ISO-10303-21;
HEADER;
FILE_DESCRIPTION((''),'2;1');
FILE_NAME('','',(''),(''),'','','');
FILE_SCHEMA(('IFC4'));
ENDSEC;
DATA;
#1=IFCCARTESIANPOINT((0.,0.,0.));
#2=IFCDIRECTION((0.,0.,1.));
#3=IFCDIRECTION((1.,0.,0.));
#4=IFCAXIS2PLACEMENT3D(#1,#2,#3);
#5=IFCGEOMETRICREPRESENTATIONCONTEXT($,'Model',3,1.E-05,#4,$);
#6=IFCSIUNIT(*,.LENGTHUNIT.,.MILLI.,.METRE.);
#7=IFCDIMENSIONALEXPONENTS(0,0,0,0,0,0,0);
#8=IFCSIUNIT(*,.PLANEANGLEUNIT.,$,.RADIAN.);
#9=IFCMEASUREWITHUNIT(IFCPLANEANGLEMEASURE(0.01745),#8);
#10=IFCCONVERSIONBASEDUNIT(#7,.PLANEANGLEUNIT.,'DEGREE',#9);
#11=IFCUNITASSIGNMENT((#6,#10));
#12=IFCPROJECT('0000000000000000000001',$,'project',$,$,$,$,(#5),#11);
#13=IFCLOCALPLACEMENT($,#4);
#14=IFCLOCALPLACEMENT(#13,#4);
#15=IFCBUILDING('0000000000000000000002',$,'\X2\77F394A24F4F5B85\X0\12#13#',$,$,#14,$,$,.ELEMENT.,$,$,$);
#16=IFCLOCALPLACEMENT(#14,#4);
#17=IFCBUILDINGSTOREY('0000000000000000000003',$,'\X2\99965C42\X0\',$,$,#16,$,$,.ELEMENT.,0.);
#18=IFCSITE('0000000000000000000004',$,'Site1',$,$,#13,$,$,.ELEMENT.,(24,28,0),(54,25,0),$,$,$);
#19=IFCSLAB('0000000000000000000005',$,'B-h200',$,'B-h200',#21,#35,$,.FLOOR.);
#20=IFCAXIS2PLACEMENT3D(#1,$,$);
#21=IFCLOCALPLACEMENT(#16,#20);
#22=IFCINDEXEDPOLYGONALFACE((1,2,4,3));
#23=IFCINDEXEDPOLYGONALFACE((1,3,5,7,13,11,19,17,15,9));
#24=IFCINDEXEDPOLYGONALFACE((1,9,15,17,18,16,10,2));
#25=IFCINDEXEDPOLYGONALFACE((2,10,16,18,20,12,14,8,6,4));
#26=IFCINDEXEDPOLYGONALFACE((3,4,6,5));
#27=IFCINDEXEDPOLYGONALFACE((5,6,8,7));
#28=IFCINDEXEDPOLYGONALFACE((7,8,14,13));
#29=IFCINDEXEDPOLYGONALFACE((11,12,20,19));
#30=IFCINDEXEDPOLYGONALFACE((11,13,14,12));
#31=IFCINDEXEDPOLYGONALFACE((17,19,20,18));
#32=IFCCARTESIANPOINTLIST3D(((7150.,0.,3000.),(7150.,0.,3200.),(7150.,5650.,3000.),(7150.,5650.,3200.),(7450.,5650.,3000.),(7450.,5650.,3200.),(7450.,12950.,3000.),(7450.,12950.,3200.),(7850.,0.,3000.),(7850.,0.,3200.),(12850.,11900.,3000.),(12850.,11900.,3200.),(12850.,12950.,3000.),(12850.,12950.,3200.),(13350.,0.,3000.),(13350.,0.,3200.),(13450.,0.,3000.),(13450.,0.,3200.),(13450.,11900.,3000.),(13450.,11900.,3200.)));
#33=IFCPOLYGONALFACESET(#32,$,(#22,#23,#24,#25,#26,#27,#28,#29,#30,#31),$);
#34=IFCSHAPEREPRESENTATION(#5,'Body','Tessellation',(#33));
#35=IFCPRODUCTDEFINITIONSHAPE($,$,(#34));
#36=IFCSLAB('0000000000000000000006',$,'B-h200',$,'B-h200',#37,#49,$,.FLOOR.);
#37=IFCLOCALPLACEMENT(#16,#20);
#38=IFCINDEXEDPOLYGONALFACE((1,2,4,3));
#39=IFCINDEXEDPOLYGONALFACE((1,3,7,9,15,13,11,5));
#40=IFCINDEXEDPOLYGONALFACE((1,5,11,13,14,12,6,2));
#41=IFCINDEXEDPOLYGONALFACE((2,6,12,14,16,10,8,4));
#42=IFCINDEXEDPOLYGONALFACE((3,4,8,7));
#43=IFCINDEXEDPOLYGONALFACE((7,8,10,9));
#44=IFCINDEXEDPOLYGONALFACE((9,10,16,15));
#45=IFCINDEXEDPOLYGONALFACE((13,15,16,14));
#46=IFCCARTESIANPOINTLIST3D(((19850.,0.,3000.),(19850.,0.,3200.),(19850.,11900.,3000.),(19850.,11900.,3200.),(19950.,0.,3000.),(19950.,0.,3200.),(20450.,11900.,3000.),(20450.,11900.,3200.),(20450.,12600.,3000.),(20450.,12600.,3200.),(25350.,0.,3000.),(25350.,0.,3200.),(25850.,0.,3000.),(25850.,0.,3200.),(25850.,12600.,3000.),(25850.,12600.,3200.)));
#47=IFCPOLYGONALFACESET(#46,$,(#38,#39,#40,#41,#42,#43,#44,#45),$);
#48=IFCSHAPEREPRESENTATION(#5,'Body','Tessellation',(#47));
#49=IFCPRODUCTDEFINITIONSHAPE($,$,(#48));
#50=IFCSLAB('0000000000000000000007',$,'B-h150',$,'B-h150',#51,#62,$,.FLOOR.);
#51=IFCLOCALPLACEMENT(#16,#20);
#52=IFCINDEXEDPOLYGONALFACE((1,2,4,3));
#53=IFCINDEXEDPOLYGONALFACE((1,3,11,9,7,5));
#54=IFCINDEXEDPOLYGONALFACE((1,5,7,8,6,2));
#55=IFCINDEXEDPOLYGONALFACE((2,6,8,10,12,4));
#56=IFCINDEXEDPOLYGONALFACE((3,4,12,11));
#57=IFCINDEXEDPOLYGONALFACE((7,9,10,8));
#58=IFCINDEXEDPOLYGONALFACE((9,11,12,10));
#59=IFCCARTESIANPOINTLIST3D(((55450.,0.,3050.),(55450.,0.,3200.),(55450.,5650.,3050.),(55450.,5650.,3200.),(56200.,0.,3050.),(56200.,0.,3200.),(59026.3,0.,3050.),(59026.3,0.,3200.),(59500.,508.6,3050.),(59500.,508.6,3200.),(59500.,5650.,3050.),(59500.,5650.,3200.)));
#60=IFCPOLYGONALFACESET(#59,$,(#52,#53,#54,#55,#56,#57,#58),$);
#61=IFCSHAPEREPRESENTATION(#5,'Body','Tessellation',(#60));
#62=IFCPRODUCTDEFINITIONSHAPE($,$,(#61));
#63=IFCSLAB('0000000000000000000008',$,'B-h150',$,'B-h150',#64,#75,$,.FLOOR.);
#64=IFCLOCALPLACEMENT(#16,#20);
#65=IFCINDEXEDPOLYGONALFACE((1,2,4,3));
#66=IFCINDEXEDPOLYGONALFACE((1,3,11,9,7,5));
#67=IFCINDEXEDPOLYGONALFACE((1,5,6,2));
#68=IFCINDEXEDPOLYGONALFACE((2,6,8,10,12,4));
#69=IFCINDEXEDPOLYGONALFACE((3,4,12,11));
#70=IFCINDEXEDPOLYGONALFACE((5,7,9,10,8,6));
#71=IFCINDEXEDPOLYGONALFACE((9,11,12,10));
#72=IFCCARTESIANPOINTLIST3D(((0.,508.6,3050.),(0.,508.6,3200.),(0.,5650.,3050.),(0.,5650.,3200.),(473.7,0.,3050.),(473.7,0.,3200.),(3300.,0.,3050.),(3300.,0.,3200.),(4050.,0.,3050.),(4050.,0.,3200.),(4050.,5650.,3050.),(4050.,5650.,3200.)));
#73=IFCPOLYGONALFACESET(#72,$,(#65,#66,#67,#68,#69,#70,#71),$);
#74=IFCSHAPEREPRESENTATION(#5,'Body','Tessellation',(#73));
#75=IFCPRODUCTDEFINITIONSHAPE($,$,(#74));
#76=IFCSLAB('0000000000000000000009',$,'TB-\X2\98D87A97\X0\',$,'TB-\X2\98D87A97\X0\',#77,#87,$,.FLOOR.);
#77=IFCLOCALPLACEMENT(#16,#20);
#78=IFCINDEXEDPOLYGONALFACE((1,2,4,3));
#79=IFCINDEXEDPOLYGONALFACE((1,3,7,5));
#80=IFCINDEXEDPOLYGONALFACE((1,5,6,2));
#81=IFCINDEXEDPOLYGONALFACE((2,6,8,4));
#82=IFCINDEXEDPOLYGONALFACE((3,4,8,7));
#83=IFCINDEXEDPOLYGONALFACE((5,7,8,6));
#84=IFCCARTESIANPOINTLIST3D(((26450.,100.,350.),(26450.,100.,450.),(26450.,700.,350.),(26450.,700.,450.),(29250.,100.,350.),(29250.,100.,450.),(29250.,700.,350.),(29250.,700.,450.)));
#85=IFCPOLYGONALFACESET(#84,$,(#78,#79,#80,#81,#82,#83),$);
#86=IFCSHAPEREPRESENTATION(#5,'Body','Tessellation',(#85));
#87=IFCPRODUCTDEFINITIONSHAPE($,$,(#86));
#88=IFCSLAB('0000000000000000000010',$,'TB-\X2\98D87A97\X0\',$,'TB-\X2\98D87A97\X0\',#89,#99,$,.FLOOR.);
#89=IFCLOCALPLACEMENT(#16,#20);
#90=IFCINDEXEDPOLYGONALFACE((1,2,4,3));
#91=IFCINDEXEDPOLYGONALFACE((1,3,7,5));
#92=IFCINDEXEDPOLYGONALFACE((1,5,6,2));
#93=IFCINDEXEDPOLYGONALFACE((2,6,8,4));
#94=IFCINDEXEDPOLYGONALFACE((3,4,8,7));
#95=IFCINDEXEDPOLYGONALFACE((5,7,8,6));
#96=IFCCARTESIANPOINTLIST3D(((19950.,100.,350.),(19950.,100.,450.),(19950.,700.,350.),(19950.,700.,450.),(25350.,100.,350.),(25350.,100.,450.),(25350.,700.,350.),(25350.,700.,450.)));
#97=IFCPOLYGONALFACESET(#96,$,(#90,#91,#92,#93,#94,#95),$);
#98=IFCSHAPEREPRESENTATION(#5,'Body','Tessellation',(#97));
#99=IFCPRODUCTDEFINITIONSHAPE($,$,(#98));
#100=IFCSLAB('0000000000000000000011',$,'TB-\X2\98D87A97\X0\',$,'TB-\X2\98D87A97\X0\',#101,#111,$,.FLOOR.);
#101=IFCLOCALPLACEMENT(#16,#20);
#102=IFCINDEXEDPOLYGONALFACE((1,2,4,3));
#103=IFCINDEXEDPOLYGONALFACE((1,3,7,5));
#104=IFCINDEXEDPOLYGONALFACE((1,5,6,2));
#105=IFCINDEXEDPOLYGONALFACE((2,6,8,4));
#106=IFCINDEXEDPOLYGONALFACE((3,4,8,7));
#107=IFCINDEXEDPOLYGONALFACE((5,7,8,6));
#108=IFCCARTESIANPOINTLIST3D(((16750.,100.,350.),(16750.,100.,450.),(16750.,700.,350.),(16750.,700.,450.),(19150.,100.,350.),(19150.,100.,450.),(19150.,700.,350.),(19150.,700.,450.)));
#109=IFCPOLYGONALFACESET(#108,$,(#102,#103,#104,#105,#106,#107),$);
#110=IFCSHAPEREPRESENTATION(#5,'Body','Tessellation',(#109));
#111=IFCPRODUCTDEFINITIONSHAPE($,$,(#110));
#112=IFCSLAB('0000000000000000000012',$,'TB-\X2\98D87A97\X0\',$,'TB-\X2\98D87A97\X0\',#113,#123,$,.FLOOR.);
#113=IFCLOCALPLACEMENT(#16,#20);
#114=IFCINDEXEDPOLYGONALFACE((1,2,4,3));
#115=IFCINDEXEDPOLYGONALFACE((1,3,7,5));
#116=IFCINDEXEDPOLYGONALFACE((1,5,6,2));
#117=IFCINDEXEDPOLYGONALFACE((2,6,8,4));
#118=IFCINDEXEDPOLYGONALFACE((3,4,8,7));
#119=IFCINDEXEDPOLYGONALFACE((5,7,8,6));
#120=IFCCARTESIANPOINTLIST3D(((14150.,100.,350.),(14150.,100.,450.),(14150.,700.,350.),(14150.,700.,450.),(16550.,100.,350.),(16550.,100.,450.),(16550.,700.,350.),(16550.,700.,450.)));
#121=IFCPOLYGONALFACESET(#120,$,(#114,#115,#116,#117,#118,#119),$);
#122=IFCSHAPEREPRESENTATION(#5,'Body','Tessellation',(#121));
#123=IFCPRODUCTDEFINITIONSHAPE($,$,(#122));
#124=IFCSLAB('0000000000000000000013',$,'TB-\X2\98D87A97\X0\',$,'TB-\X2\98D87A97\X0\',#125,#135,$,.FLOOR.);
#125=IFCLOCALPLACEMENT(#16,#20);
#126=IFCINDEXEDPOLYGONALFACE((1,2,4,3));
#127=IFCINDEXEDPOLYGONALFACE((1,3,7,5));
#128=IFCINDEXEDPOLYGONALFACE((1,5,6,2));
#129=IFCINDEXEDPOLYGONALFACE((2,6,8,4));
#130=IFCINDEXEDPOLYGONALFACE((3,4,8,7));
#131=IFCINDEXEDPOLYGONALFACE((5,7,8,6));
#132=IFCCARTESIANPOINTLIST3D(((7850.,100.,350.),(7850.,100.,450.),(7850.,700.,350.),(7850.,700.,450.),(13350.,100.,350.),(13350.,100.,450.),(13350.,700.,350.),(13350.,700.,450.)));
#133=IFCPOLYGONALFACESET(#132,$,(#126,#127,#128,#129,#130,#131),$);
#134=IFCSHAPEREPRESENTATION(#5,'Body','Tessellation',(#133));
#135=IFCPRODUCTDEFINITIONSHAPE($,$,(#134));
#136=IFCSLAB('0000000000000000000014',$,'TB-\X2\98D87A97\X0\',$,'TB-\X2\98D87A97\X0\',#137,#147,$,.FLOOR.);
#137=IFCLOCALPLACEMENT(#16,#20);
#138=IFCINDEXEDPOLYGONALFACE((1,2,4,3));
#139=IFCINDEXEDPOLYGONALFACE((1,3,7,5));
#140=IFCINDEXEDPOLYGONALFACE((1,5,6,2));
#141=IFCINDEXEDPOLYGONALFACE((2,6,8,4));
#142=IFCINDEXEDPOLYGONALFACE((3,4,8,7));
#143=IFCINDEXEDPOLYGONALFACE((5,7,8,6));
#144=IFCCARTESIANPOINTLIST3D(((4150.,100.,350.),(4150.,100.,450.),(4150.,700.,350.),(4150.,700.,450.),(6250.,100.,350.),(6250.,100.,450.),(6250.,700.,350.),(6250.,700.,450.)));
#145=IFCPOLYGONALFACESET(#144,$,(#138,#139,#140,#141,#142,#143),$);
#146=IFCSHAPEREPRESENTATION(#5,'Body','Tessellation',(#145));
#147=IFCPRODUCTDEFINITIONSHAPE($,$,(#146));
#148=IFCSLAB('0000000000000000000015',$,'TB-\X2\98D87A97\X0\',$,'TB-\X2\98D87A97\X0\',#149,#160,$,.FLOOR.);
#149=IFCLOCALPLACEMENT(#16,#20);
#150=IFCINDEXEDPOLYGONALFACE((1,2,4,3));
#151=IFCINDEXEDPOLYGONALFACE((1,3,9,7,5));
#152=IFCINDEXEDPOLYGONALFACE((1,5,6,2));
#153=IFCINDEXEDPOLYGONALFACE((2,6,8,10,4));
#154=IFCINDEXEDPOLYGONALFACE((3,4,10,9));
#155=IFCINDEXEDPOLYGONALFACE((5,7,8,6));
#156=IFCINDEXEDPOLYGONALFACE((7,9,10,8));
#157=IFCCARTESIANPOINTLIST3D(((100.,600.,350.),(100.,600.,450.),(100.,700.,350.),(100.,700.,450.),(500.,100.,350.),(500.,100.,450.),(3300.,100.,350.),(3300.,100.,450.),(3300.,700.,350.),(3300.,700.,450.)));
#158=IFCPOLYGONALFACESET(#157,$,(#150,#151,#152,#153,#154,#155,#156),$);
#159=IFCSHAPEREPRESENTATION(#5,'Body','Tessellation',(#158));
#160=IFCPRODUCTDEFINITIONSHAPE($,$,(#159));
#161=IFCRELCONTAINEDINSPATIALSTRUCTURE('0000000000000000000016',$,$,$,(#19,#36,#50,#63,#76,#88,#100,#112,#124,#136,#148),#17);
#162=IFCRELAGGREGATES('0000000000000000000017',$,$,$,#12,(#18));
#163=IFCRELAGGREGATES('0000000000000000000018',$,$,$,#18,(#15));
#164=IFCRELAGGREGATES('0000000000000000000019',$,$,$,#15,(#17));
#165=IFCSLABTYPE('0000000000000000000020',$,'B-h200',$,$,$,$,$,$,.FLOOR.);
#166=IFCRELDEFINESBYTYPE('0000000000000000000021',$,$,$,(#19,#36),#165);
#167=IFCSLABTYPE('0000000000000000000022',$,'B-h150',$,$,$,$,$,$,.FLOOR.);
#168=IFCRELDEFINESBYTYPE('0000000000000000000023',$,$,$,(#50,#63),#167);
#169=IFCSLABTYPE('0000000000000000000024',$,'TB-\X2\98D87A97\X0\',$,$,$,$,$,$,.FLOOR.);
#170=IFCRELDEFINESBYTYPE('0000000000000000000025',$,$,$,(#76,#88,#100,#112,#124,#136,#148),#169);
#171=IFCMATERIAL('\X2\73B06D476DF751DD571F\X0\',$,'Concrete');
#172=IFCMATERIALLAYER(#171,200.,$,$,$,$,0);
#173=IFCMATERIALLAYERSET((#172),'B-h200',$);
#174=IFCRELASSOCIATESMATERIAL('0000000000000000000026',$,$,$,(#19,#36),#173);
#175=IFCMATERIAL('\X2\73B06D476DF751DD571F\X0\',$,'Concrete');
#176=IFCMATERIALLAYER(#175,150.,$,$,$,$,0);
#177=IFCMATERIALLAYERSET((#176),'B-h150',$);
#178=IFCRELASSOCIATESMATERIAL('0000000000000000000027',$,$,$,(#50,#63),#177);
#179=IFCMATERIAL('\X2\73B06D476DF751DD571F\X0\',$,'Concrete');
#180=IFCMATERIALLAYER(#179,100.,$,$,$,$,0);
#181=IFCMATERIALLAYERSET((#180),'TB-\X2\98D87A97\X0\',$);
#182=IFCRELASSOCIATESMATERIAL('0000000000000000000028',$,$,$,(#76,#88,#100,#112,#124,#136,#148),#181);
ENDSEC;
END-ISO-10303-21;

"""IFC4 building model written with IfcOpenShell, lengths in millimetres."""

from ifc_helpers import new_model, entity, si_unit, converted_unit, point, frame, frame_2d, origin_with_axes, place, context, project, spatial, polyline, circle_curve, trimmed, segment, composite_curve, outline, extrude, material, layer, layer_set, type_object, element, save


model = new_model("IFC4")

# Units and contexts
model_context = context("Model", 3, precision=1e-05, world=origin_with_axes())
ifc_project = project(units=[si_unit("LENGTHUNIT", "METRE", prefix="MILLI"), converted_unit("PLANEANGLEUNIT", "DEGREE", entity("IfcPlaneAngleMeasure", 0.01745), si_unit("PLANEANGLEUNIT", "RADIAN"), dimensions=[0, 0, 0, 0, 0, 0, 0])], contexts=[model_context])

# Site, building, storey
site_placement = place(None, origin_with_axes())
site = spatial("IfcSite", under=ifc_project, at=site_placement, Name="Site1", CompositionType="ELEMENT", RefLatitude=(24, 28, 0), RefLongitude=(54, 25, 0))
building_placement = place(site_placement, origin_with_axes())
building = spatial("IfcBuilding", under=site, at=building_placement, Name="石钢住宅12#13#", CompositionType="ELEMENT")
storey_placement = place(building_placement, origin_with_axes())
storey = spatial("IfcBuildingStorey", under=building, at=storey_placement, Name="首层", CompositionType="ELEMENT", Elevation=0.0)

# Slabs, openings
ifc_material_1 = material(Name="现浇混凝土", Category="Concrete")
ifc_layer_1 = layer(ifc_material_1, 200.0, Priority=0)
ifc_layer_set_1 = layer_set([ifc_layer_1], Name="B-h200")
slab_type_1 = type_object("IfcSlabType", Name="B-h200", PredefinedType="FLOOR")
slab_1_placement = place(storey_placement, origin_with_axes())
slab_1 = element("IfcSlab", 1, at=slab_1_placement, inside=storey, type_object=slab_type_1, material=ifc_layer_set_1, Name="B-h200", ObjectType="B-h200", PredefinedType="FLOOR", context=model_context, shape_type="SweptSolid", body=[
    extrude(outline(polyline([(7450.0, -12950.0), (12850.0, -12950.0), (12850.0, -11900.0), (13450.0, -11900.0), (13450.0, 0.0), (13350.0, 0.0), (13350.0, 0.0), (7850.0, 0.0), (7850.0, 0.0), (7150.0, 0.0), (7150.0, -5650.0), (7450.0, -5650.0), (7450.0, -12950.0)])), frame((0.0, 0.0, 3200.0), z_axis=(0.0, 0.0, -1.0), x_axis=(1.0, 0.0, 0.0)), (0.0, 0.0, 1.0), 200.0),
])
opening_1_placement = place(storey_placement, origin_with_axes())
element("IfcOpeningElement", 2, at=opening_1_placement, cuts=slab_1, PredefinedType="OPENING", context=model_context, shape_type="SweptSolid", body=[
    extrude(outline(polyline([(0.0, 0.0), (400.0, 0.0), (400.0, 350.0), (0.0, 350.0), (0.0, 0.0)])), frame((7550.0, 9200.0, -6400.0), z_axis=(0.0, 0.0, 1.0), x_axis=(1.0, 0.0, 0.0)), (0.0, 0.0, 1.0), 19200.0),
])
slab_2_placement = place(storey_placement, origin_with_axes())
slab_2 = element("IfcSlab", 3, at=slab_2_placement, inside=storey, type_object=slab_type_1, material=ifc_layer_set_1, Name="B-h200", ObjectType="B-h200", PredefinedType="FLOOR", context=model_context, shape_type="SweptSolid", body=[
    extrude(outline(polyline([(25850.0, -12600.0), (25850.0, 0.0), (25350.0, 0.0), (25350.0, 0.0), (19950.0, 0.0), (19950.0, 0.0), (19850.0, 0.0), (19850.0, -11900.0), (20450.0, -11900.0), (20450.0, -12600.0), (25850.0, -12600.0)])), frame((0.0, 0.0, 3200.0), z_axis=(0.0, 0.0, -1.0), x_axis=(1.0, 0.0, 0.0)), (0.0, 0.0, 1.0), 200.0),
])
opening_2_placement = place(storey_placement, origin_with_axes())
element("IfcOpeningElement", 4, at=opening_2_placement, cuts=slab_2, PredefinedType="OPENING", context=model_context, shape_type="SweptSolid", body=[
    extrude(outline(polyline([(0.0, 0.0), (400.0, 0.0), (400.0, 350.0), (0.0, 350.0), (0.0, 0.0)])), frame((25350.0, 10800.0, -6400.0), z_axis=(0.0, 0.0, 1.0), x_axis=(1.0, 0.0, 0.0)), (0.0, 0.0, 1.0), 19200.0),
])

# Slabs
ifc_material_2 = material(Name="现浇混凝土", Category="Concrete")
ifc_layer_2 = layer(ifc_material_2, 150.0, Priority=0)
ifc_layer_set_2 = layer_set([ifc_layer_2], Name="B-h150")
slab_type_2 = type_object("IfcSlabType", Name="B-h150", PredefinedType="FLOOR")
slab_3_placement = place(storey_placement, origin_with_axes())
element("IfcSlab", 5, at=slab_3_placement, inside=storey, type_object=slab_type_2, material=ifc_layer_set_2, Name="B-h150", ObjectType="B-h150", PredefinedType="FLOOR", context=model_context, shape_type="SweptSolid", body=[
    extrude(outline(composite_curve([segment(trimmed(circle_curve(frame_2d((479.5, 480.3), x_axis=(1.0, 0.0)), 480.3), [point((0.0, 508.6))], [point((473.7, 0.0))], True, "CARTESIAN"), True, "CONTINUOUS"), segment(polyline([(473.7, 0.0), (3300.0, 0.0)]), True, "CONTINUOUS"), segment(polyline([(3300.0, 0.0), (4050.0, 0.0)]), True, "CONTINUOUS"), segment(polyline([(4050.0, 0.0), (4050.0, 5650.0)]), True, "CONTINUOUS"), segment(polyline([(4050.0, 5650.0), (0.0, 5650.0)]), True, "CONTINUOUS"), segment(polyline([(0.0, 5650.0), (0.0, 508.6)]), True, "CONTINUOUS")], self_intersect=False)), frame((59500.0, 0.0, 3200.0), z_axis=(0.0, 0.0, -1.0), x_axis=(-1.0, 0.0, 0.0)), (0.0, 0.0, 1.0), 150.0),
])
slab_4_placement = place(storey_placement, origin_with_axes())
element("IfcSlab", 6, at=slab_4_placement, inside=storey, type_object=slab_type_2, material=ifc_layer_set_2, Name="B-h150", ObjectType="B-h150", PredefinedType="FLOOR", context=model_context, shape_type="SweptSolid", body=[
    extrude(outline(composite_curve([segment(polyline([(0.0, -508.6), (0.0, -5650.0)]), True, "CONTINUOUS"), segment(polyline([(0.0, -5650.0), (4050.0, -5650.0)]), True, "CONTINUOUS"), segment(polyline([(4050.0, -5650.0), (4050.0, 0.0)]), True, "CONTINUOUS"), segment(polyline([(4050.0, 0.0), (3300.0, 0.0)]), True, "CONTINUOUS"), segment(polyline([(3300.0, 0.0), (473.7, 0.0)]), True, "CONTINUOUS"), segment(trimmed(circle_curve(frame_2d((479.5, -480.3), x_axis=(1.0, 0.0)), 480.3), [point((473.7, 0.0))], [point((0.0, -508.6))], True, "CARTESIAN"), True, "CONTINUOUS")], self_intersect=False)), frame((0.0, 0.0, 3200.0), z_axis=(0.0, 0.0, -1.0), x_axis=(1.0, 0.0, 0.0)), (0.0, 0.0, 1.0), 150.0),
])
ifc_material_3 = material(Name="现浇混凝土", Category="Concrete")
ifc_layer_3 = layer(ifc_material_3, 100.0, Priority=0)
ifc_layer_set_3 = layer_set([ifc_layer_3], Name="TB-飘窗")
slab_type_3 = type_object("IfcSlabType", Name="TB-飘窗", PredefinedType="FLOOR")
slab_5_placement = place(storey_placement, origin_with_axes())
element("IfcSlab", 7, at=slab_5_placement, inside=storey, type_object=slab_type_3, material=ifc_layer_set_3, Name="TB-飘窗", ObjectType="TB-飘窗", PredefinedType="FLOOR", context=model_context, shape_type="SweptSolid", body=[
    extrude(outline(polyline([(0.0, 0.0), (600.0, 0.0), (600.0, 2800.0), (0.0, 2800.0), (0.0, 0.0)])), frame((26450.0, 100.0, 450.0), z_axis=(0.0, 0.0, -1.0), x_axis=(0.0, 1.0, 0.0)), (0.0, 0.0, 1.0), 100.0),
])
slab_6_placement = place(storey_placement, origin_with_axes())
element("IfcSlab", 8, at=slab_6_placement, inside=storey, type_object=slab_type_3, material=ifc_layer_set_3, Name="TB-飘窗", ObjectType="TB-飘窗", PredefinedType="FLOOR", context=model_context, shape_type="SweptSolid", body=[
    extrude(outline(polyline([(0.0, 0.0), (600.0, 0.0), (600.0, 5400.0), (0.0, 5400.0), (0.0, 0.0)])), frame((19950.0, 100.0, 450.0), z_axis=(0.0, 0.0, -1.0), x_axis=(0.0, 1.0, 0.0)), (0.0, 0.0, 1.0), 100.0),
])
slab_7_placement = place(storey_placement, origin_with_axes())
element("IfcSlab", 9, at=slab_7_placement, inside=storey, type_object=slab_type_3, material=ifc_layer_set_3, Name="TB-飘窗", ObjectType="TB-飘窗", PredefinedType="FLOOR", context=model_context, shape_type="SweptSolid", body=[
    extrude(outline(polyline([(0.0, 0.0), (2400.0, 0.0), (2400.0, 600.0), (0.0, 600.0), (0.0, 0.0)])), frame((19150.0, 100.0, 450.0), z_axis=(0.0, 0.0, -1.0), x_axis=(-1.0, 0.0, 0.0)), (0.0, 0.0, 1.0), 100.0),
])
slab_8_placement = place(storey_placement, origin_with_axes())
element("IfcSlab", 10, at=slab_8_placement, inside=storey, type_object=slab_type_3, material=ifc_layer_set_3, Name="TB-飘窗", ObjectType="TB-飘窗", PredefinedType="FLOOR", context=model_context, shape_type="SweptSolid", body=[
    extrude(outline(polyline([(0.0, 0.0), (600.0, 0.0), (600.0, 2400.0), (0.0, 2400.0), (0.0, 0.0)])), frame((14150.0, 100.0, 450.0), z_axis=(0.0, 0.0, -1.0), x_axis=(0.0, 1.0, 0.0)), (0.0, 0.0, 1.0), 100.0),
])
slab_9_placement = place(storey_placement, origin_with_axes())
element("IfcSlab", 11, at=slab_9_placement, inside=storey, type_object=slab_type_3, material=ifc_layer_set_3, Name="TB-飘窗", ObjectType="TB-飘窗", PredefinedType="FLOOR", context=model_context, shape_type="SweptSolid", body=[
    extrude(outline(polyline([(0.0, 0.0), (600.0, 0.0), (600.0, 5500.0), (0.0, 5500.0), (0.0, 0.0)])), frame((7850.0, 100.0, 450.0), z_axis=(0.0, 0.0, -1.0), x_axis=(0.0, 1.0, 0.0)), (0.0, 0.0, 1.0), 100.0),
])
slab_10_placement = place(storey_placement, origin_with_axes())
element("IfcSlab", 12, at=slab_10_placement, inside=storey, type_object=slab_type_3, material=ifc_layer_set_3, Name="TB-飘窗", ObjectType="TB-飘窗", PredefinedType="FLOOR", context=model_context, shape_type="SweptSolid", body=[
    extrude(outline(polyline([(0.0, 0.0), (2100.0, 0.0), (2100.0, 600.0), (0.0, 600.0), (0.0, 0.0)])), frame((4150.0, 700.0, 450.0), z_axis=(0.0, 0.0, -1.0), x_axis=(1.0, 0.0, 0.0)), (0.0, 0.0, 1.0), 100.0),
])
slab_11_placement = place(storey_placement, origin_with_axes())
element("IfcSlab", 13, at=slab_11_placement, inside=storey, type_object=slab_type_3, material=ifc_layer_set_3, Name="TB-飘窗", ObjectType="TB-飘窗", PredefinedType="FLOOR", context=model_context, shape_type="SweptSolid", body=[
    extrude(outline(composite_curve([segment(polyline([(100.0, -700.0), (3300.0, -700.0)]), True, "CONTINUOUS"), segment(polyline([(3300.0, -700.0), (3300.0, -100.0)]), True, "CONTINUOUS"), segment(polyline([(3300.0, -100.0), (500.0, -100.0)]), True, "CONTINUOUS"), segment(trimmed(circle_curve(frame_2d((506.2, -515.0), x_axis=(1.0, 0.0)), 415.0), [point((500.0, -100.0))], [point((100.0, -600.0))], True, "CARTESIAN"), True, "CONTINUOUS"), segment(polyline([(100.0, -600.0), (100.0, -700.0)]), True, "CONTINUOUS")], self_intersect=False)), frame((0.0, 0.0, 450.0), z_axis=(0.0, 0.0, -1.0), x_axis=(1.0, 0.0, 0.0)), (0.0, 0.0, 1.0), 100.0),
])

save(model, "model.ifc")
